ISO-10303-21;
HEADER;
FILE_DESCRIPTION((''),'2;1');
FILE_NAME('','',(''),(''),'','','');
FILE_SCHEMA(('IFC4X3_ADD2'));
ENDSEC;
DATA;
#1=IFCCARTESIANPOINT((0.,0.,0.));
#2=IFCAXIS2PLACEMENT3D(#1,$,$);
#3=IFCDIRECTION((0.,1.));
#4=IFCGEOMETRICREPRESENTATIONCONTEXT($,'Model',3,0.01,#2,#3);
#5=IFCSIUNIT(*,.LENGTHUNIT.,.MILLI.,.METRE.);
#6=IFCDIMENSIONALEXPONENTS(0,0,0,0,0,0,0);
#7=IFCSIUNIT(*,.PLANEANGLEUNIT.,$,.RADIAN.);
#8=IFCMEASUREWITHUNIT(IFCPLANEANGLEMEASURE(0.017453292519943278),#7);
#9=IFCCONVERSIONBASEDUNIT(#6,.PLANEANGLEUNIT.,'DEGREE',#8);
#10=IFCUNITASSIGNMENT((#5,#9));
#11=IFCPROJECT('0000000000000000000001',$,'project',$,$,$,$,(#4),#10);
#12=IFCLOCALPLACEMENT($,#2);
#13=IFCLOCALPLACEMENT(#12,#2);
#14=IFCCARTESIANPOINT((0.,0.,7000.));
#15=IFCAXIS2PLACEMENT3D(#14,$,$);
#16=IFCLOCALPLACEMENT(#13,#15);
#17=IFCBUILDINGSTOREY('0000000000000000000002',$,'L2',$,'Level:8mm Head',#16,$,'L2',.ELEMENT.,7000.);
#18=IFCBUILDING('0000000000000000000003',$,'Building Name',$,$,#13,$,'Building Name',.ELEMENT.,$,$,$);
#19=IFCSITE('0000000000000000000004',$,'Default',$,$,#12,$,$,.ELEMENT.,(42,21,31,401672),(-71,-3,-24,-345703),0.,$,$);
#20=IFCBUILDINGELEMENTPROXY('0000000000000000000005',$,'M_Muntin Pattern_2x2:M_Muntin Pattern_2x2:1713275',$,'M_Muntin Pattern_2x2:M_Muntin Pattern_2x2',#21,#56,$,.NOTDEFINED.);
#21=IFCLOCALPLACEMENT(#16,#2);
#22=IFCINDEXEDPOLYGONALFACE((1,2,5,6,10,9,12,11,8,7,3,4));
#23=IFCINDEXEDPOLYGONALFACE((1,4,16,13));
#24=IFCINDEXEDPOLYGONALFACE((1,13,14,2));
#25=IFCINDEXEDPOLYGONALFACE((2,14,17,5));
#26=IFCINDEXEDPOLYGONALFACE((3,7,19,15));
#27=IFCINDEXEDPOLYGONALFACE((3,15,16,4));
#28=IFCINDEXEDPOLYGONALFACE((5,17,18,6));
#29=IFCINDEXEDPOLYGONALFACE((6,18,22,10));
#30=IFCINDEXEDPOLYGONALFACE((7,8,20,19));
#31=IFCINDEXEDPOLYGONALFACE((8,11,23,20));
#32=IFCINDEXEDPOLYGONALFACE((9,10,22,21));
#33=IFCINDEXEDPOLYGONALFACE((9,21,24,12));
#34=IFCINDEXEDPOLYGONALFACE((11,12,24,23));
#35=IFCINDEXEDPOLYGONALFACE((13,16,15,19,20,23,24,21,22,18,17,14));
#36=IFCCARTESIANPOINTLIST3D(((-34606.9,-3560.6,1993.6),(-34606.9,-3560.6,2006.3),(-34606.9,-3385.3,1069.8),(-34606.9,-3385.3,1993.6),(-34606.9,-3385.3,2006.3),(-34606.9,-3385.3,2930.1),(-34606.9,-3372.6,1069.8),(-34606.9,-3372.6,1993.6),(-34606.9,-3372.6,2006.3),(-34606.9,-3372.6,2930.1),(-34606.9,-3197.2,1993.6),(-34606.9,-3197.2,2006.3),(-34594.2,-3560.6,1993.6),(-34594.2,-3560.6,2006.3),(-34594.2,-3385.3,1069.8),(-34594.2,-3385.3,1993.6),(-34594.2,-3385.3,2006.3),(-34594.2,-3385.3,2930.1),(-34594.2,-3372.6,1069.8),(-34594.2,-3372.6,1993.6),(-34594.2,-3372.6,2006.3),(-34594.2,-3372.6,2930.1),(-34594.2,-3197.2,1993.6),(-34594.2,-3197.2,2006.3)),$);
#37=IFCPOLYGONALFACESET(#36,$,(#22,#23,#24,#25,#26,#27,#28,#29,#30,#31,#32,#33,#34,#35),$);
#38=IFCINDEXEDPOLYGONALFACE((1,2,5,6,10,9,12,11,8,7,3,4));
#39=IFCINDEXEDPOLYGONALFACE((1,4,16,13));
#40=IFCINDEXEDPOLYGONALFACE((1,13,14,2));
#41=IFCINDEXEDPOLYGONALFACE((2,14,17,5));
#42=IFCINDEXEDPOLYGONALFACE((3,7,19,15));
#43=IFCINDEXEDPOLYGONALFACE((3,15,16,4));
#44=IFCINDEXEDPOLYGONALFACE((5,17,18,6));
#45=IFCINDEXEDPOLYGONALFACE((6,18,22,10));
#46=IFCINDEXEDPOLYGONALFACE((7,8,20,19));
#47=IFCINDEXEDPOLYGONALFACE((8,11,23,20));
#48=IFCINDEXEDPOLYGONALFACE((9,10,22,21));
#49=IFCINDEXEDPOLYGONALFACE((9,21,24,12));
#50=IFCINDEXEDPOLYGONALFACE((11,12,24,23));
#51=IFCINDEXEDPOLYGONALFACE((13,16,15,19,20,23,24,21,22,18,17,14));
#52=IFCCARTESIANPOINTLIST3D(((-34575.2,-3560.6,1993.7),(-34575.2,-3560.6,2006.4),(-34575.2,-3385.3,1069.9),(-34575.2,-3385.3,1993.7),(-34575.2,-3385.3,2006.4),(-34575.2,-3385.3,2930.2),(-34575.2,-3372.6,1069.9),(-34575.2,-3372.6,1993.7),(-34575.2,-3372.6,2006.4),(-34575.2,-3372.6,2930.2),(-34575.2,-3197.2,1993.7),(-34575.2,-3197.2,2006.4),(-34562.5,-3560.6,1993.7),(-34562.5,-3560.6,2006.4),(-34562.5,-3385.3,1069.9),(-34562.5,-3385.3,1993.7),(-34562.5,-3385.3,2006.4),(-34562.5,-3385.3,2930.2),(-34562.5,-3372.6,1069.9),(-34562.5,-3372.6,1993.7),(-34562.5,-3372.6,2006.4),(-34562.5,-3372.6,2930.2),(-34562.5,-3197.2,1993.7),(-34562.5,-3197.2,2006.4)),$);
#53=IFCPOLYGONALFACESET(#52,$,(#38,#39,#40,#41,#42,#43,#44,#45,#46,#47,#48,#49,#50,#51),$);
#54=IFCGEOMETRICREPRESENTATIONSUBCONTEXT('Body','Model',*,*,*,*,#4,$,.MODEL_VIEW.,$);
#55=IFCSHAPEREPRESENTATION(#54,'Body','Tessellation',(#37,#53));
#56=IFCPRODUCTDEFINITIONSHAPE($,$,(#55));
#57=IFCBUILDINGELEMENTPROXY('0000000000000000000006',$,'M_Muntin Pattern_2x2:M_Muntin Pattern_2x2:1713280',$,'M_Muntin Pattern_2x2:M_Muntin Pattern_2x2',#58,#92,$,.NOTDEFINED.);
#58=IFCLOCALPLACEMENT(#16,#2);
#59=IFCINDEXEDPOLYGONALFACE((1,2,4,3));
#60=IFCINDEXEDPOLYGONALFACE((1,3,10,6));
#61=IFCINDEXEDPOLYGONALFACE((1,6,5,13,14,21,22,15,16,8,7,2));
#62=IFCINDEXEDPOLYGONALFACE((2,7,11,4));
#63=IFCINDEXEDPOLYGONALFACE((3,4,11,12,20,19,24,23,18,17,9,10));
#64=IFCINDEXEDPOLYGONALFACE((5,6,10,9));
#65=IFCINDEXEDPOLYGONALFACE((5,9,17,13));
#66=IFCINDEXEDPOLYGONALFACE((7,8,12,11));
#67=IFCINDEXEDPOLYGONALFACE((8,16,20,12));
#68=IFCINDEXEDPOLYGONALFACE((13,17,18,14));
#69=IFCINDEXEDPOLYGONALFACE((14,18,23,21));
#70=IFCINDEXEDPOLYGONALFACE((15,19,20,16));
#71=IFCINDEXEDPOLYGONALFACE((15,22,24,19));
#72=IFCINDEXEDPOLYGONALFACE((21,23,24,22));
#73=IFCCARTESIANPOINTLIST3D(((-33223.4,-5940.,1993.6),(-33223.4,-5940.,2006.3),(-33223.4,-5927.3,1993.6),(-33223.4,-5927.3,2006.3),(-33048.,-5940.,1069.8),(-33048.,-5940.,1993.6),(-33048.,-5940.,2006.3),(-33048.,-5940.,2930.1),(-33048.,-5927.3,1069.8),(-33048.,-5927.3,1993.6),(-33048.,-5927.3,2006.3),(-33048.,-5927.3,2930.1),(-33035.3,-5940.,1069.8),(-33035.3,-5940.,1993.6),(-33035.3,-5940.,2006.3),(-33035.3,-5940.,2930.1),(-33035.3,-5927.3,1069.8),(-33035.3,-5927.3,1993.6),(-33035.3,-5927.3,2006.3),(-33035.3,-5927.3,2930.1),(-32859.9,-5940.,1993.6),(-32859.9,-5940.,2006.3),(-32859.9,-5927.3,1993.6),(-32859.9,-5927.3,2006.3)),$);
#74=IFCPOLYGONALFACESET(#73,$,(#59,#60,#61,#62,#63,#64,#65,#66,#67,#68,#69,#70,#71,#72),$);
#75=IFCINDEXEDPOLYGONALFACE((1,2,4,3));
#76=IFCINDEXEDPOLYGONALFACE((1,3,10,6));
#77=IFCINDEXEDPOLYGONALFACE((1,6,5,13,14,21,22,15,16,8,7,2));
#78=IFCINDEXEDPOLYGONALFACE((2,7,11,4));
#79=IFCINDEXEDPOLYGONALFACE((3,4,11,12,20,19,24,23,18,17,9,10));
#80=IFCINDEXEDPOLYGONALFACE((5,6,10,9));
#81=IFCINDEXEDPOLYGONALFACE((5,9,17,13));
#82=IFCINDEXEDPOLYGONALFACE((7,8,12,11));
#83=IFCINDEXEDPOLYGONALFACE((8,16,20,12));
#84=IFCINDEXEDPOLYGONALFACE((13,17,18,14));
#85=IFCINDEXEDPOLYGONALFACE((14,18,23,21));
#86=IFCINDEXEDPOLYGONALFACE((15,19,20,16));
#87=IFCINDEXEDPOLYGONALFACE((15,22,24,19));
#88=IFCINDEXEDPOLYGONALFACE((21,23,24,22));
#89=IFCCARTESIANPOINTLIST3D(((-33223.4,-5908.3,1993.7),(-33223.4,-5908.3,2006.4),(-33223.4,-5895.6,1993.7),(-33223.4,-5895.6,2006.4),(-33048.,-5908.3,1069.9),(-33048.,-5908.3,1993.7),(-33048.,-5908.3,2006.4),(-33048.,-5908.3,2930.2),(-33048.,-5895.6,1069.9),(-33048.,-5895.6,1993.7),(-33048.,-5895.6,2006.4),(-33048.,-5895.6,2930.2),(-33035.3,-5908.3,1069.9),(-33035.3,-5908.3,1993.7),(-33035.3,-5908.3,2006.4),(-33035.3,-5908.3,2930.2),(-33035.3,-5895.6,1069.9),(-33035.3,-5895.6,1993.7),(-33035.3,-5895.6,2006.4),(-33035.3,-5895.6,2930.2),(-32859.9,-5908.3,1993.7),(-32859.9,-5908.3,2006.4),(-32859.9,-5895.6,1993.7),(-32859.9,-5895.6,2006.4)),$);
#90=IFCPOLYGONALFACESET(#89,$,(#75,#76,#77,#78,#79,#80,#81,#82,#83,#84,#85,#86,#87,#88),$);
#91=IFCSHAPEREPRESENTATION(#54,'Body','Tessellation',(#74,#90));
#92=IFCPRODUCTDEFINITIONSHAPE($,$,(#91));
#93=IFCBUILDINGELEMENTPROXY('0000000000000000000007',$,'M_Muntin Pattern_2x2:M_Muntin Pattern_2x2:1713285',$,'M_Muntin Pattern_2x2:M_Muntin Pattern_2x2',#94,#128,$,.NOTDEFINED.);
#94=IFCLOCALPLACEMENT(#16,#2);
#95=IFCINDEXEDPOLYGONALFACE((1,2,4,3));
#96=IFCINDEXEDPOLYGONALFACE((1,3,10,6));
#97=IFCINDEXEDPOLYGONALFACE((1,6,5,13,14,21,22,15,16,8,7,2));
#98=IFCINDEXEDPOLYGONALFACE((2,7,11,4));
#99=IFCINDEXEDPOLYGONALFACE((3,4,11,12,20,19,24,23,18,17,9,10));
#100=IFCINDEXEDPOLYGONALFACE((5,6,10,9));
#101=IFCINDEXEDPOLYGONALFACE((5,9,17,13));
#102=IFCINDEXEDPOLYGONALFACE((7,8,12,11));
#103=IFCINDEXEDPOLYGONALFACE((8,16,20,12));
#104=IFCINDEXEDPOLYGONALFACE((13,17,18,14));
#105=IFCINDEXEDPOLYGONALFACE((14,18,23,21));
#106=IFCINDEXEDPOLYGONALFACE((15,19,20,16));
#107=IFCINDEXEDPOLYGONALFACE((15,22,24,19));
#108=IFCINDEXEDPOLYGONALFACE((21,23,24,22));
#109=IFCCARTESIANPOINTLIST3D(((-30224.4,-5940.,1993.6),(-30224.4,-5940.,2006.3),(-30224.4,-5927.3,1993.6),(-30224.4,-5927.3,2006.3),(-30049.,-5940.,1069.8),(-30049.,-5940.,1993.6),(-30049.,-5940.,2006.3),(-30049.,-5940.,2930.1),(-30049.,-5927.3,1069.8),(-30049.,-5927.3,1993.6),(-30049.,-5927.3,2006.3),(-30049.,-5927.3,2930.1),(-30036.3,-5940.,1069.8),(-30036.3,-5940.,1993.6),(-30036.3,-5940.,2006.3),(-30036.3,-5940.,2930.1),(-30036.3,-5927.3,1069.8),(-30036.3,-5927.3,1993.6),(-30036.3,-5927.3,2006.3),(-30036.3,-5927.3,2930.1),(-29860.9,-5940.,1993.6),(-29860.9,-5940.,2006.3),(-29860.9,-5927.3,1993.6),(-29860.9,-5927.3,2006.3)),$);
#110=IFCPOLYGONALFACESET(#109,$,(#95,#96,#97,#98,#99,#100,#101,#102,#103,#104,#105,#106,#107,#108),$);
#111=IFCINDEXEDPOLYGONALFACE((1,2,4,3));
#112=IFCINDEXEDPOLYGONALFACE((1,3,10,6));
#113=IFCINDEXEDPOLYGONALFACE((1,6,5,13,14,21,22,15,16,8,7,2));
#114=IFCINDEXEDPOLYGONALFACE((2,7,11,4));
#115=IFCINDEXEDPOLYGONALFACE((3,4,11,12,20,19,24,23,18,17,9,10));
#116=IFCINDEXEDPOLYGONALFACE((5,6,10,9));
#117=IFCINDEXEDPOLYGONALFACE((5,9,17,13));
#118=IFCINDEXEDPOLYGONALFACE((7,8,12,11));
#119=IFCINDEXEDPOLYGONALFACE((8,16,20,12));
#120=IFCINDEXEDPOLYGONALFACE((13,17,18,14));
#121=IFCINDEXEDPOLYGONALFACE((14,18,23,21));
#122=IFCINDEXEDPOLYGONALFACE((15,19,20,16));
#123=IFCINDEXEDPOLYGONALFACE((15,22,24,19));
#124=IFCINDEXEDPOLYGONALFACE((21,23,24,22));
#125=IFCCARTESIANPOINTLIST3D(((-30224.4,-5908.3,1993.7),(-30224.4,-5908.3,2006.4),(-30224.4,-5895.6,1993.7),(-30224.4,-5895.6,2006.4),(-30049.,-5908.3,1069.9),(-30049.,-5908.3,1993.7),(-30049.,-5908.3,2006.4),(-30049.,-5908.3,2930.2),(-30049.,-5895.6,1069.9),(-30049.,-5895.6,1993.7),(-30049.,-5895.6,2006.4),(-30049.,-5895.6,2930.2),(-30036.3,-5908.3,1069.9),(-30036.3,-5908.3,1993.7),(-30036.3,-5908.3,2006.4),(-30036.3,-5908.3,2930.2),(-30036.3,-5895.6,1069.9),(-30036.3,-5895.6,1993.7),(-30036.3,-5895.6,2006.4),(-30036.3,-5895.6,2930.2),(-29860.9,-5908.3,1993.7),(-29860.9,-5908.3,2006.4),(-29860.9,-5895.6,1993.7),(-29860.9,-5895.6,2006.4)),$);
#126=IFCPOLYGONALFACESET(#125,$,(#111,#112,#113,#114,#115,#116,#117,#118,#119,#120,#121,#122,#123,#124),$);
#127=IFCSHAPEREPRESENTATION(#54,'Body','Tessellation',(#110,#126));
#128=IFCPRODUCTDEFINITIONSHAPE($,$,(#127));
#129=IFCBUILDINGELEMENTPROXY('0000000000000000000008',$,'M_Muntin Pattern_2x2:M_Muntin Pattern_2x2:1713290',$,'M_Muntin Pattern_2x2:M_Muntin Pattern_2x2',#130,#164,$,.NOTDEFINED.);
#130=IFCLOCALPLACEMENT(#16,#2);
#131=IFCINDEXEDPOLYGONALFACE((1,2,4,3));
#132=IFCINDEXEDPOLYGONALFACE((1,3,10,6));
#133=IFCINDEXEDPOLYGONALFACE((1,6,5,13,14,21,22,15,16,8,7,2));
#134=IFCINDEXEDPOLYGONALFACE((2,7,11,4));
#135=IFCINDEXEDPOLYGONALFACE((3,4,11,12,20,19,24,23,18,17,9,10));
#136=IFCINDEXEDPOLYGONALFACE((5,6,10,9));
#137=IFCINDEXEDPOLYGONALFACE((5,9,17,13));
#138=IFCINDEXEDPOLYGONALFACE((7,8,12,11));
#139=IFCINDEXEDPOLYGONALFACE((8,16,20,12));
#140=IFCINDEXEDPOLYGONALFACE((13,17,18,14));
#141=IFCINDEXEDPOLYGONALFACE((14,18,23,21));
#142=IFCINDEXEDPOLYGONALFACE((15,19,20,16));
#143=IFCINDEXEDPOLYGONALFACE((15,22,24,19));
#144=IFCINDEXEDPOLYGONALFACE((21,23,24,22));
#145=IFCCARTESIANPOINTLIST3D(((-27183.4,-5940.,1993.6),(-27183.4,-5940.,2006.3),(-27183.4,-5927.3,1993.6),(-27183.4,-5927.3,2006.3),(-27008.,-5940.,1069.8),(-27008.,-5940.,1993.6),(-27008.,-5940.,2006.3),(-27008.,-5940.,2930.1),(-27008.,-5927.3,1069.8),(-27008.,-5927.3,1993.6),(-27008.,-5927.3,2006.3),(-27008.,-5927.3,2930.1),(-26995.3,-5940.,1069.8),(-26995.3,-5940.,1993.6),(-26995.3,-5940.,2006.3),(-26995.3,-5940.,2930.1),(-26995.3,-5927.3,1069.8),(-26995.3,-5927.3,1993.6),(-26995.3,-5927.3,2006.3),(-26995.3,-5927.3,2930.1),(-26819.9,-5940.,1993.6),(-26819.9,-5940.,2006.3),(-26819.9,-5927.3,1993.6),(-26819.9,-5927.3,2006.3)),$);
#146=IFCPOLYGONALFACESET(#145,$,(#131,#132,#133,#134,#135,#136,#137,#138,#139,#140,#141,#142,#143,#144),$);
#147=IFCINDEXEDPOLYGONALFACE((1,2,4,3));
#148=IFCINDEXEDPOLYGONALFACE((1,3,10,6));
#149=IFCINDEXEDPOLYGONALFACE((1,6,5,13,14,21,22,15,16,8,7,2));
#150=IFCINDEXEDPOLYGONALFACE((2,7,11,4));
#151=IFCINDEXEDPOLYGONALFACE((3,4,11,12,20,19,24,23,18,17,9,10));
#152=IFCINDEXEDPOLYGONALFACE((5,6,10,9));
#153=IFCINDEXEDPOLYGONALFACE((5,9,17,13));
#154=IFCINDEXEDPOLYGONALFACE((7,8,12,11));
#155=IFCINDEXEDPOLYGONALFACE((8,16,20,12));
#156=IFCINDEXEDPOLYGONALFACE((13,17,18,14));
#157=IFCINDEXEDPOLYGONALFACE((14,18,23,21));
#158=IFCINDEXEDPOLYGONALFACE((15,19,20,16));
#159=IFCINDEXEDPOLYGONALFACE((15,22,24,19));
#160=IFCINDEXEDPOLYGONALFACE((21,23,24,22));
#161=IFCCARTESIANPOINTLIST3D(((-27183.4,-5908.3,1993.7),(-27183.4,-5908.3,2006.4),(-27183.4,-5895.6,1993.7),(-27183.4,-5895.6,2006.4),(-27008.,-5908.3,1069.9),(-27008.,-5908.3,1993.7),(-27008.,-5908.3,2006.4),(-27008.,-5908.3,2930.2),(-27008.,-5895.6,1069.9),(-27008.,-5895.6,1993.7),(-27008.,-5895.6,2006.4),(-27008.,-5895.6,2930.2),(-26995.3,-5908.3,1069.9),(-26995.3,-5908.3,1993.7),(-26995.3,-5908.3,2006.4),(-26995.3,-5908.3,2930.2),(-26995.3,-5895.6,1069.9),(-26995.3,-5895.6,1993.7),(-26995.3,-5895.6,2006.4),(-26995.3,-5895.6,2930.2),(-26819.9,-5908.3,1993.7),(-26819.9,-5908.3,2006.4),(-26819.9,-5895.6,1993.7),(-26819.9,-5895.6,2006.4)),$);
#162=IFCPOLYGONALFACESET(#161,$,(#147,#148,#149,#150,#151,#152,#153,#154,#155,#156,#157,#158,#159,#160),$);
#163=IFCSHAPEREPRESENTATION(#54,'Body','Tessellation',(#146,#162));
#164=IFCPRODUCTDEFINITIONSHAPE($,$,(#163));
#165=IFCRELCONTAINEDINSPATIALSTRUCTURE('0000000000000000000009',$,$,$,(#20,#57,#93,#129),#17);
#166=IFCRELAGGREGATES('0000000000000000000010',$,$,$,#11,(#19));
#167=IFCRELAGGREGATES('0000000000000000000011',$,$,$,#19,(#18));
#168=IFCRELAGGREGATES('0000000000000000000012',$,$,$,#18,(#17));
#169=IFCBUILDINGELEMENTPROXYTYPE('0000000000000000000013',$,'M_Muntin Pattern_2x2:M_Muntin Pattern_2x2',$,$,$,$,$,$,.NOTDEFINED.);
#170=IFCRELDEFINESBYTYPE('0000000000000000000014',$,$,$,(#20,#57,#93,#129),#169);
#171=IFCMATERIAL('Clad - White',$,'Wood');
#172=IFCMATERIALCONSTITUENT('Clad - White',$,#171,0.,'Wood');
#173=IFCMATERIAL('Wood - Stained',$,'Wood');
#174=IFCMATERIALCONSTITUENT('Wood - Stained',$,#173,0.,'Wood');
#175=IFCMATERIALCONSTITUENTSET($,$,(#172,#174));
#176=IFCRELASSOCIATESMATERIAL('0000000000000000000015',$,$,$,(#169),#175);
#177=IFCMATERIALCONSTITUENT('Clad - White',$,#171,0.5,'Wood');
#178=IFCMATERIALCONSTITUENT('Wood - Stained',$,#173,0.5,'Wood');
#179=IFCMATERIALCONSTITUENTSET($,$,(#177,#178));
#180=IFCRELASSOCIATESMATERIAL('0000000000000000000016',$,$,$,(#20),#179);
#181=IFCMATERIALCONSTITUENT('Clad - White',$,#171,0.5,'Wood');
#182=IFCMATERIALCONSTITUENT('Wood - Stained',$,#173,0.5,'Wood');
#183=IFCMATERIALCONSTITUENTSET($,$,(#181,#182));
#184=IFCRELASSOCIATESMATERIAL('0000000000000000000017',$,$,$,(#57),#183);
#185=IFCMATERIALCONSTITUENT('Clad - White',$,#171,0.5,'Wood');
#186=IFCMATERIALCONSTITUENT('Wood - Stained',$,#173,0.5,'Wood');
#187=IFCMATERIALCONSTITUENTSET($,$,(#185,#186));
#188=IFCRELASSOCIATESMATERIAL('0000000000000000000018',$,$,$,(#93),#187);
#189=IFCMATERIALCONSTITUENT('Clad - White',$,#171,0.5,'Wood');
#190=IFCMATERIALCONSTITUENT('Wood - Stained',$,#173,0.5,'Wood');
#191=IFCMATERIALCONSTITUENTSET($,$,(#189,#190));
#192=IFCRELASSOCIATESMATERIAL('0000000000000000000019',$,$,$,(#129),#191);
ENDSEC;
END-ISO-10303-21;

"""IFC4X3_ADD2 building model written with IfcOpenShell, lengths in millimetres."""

from ifc_helpers import new_model, entity, si_unit, converted_unit, direction, frame, origin, place, context, subcontext, project, spatial, polyline, outline, extrude, source, transform, mapped, material, constituent, constituent_set, type_object, type_shapes, element, save


model = new_model("IFC4X3_ADD2")

# Units and contexts
model_context = context("Model", 3, precision=0.01, world=origin(), true_north=direction((0.0, 1.0)))
body_context = subcontext(model_context, "Body", "Model", "MODEL_VIEW")
ifc_project = project(units=[si_unit("LENGTHUNIT", "METRE", prefix="MILLI"), converted_unit("PLANEANGLEUNIT", "DEGREE", entity("IfcPlaneAngleMeasure", 0.017453292519943278), si_unit("PLANEANGLEUNIT", "RADIAN"), dimensions=[0, 0, 0, 0, 0, 0, 0])], contexts=[model_context])

# Site, building, storey
site_placement = place(None, origin())
site = spatial("IfcSite", under=ifc_project, at=site_placement, Name="Default", CompositionType="ELEMENT", RefLatitude=(42, 21, 31, 401672), RefLongitude=(-71, -3, -24, -345703), RefElevation=0.0)
building_placement = place(site_placement, origin())
building = spatial("IfcBuilding", under=site, at=building_placement, Name="Building Name", LongName="Building Name", CompositionType="ELEMENT")
storey_placement = place(building_placement, frame((0.0, 0.0, 7000.0)))
storey = spatial("IfcBuildingStorey", under=building, at=storey_placement, Name="L2", ObjectType="Level:8mm Head", LongName="L2", CompositionType="ELEMENT", Elevation=7000.0)

# Building element proxies
ifc_material_1 = material(Name="Clad - White", Category="Wood")
ifc_material_2 = material(Name="Wood - Stained", Category="Wood")
ifc_constituent_1 = constituent(ifc_material_1, Name="Clad - White", Category="Wood", fraction=0.5)
ifc_constituent_2 = constituent(ifc_material_2, Name="Wood - Stained", Category="Wood", fraction=0.5)
ifc_constituent_set_1 = constituent_set(constituents=[ifc_constituent_1, ifc_constituent_2])
ifc_constituent_3 = constituent(ifc_material_1, Name="Clad - White", Category="Wood", fraction=0.0)
ifc_constituent_4 = constituent(ifc_material_2, Name="Wood - Stained", Category="Wood", fraction=0.0)
ifc_constituent_set_2 = constituent_set(constituents=[ifc_constituent_3, ifc_constituent_4])
building_element_proxy_type_1 = type_object("IfcBuildingElementProxyType", Name="M_Muntin Pattern_2x2:M_Muntin Pattern_2x2", PredefinedType="NOTDEFINED", material=ifc_constituent_set_2)
shared_shape_1 = source(origin(), body_context, "Body", "SweptSolid", [
    extrude(outline(polyline([(6.4, -6.4), (930.1, -6.4), (930.1, 6.3), (6.4, 6.3), (6.4, 181.7), (-6.3, 181.7), (-6.3, 6.3), (-930.2, 6.3), (-930.2, -6.4), (-6.3, -6.4), (-6.3, -181.7), (6.4, -181.7), (6.4, -6.4)])), frame((0.0, -22.2, 930.1), z_axis=(0.0, 1.0, 0.0), x_axis=(0.0, 0.0, 1.0)), (0.0, 0.0, 1.0), 12.7),
    extrude(outline(polyline([(6.4, -6.4), (930.2, -6.4), (930.2, 6.3), (6.4, 6.3), (6.4, 181.7), (-6.3, 181.7), (-6.3, 6.3), (-930.2, 6.3), (-930.2, -6.4), (-6.3, -6.4), (-6.3, -181.7), (6.4, -181.7), (6.4, -6.4)])), frame((0.0, 9.5, 930.2), z_axis=(0.0, 1.0, 0.0), x_axis=(0.0, 0.0, 1.0)), (0.0, 0.0, 1.0), 12.7),
])
type_shapes(building_element_proxy_type_1, [shared_shape_1])
proxy_1_placement = place(storey_placement, frame((-34584.7, -3378.9, 1069.9), z_axis=(0.0, 0.0, 1.0), x_axis=(0.0, -1.0, 0.0)))
element("IfcBuildingElementProxy", 1, at=proxy_1_placement, inside=storey, type_object=building_element_proxy_type_1, material=ifc_constituent_set_1, Name="M_Muntin Pattern_2x2:M_Muntin Pattern_2x2:1713275", ObjectType="M_Muntin Pattern_2x2:M_Muntin Pattern_2x2", PredefinedType="NOTDEFINED", context=body_context, shape_type="MappedRepresentation", body=[
    mapped(shared_shape_1, transform((0.0, 0.0, 0.0), scale=1.0)),
])
ifc_constituent_5 = constituent(ifc_material_1, Name="Clad - White", Category="Wood", fraction=0.5)
ifc_constituent_6 = constituent(ifc_material_2, Name="Wood - Stained", Category="Wood", fraction=0.5)
ifc_constituent_set_3 = constituent_set(constituents=[ifc_constituent_5, ifc_constituent_6])
proxy_2_placement = place(storey_placement, frame((-33041.6, -5917.8, 1069.9)))
element("IfcBuildingElementProxy", 2, at=proxy_2_placement, inside=storey, type_object=building_element_proxy_type_1, material=ifc_constituent_set_3, Name="M_Muntin Pattern_2x2:M_Muntin Pattern_2x2:1713280", ObjectType="M_Muntin Pattern_2x2:M_Muntin Pattern_2x2", PredefinedType="NOTDEFINED", context=body_context, shape_type="MappedRepresentation", body=[
    mapped(shared_shape_1, transform((0.0, 0.0, 0.0), scale=1.0)),
])
ifc_constituent_7 = constituent(ifc_material_1, Name="Clad - White", Category="Wood", fraction=0.5)
ifc_constituent_8 = constituent(ifc_material_2, Name="Wood - Stained", Category="Wood", fraction=0.5)
ifc_constituent_set_4 = constituent_set(constituents=[ifc_constituent_7, ifc_constituent_8])
proxy_3_placement = place(storey_placement, frame((-30042.6, -5917.8, 1069.9)))
element("IfcBuildingElementProxy", 3, at=proxy_3_placement, inside=storey, type_object=building_element_proxy_type_1, material=ifc_constituent_set_4, Name="M_Muntin Pattern_2x2:M_Muntin Pattern_2x2:1713285", ObjectType="M_Muntin Pattern_2x2:M_Muntin Pattern_2x2", PredefinedType="NOTDEFINED", context=body_context, shape_type="MappedRepresentation", body=[
    mapped(shared_shape_1, transform((0.0, 0.0, 0.0), scale=1.0)),
])
ifc_constituent_9 = constituent(ifc_material_1, Name="Clad - White", Category="Wood", fraction=0.5)
ifc_constituent_10 = constituent(ifc_material_2, Name="Wood - Stained", Category="Wood", fraction=0.5)
ifc_constituent_set_5 = constituent_set(constituents=[ifc_constituent_9, ifc_constituent_10])
proxy_4_placement = place(storey_placement, frame((-27001.6, -5917.8, 1069.9)))
element("IfcBuildingElementProxy", 4, at=proxy_4_placement, inside=storey, type_object=building_element_proxy_type_1, material=ifc_constituent_set_5, Name="M_Muntin Pattern_2x2:M_Muntin Pattern_2x2:1713290", ObjectType="M_Muntin Pattern_2x2:M_Muntin Pattern_2x2", PredefinedType="NOTDEFINED", context=body_context, shape_type="MappedRepresentation", body=[
    mapped(shared_shape_1, transform((0.0, 0.0, 0.0), scale=1.0)),
])

save(model, "model.ifc")
